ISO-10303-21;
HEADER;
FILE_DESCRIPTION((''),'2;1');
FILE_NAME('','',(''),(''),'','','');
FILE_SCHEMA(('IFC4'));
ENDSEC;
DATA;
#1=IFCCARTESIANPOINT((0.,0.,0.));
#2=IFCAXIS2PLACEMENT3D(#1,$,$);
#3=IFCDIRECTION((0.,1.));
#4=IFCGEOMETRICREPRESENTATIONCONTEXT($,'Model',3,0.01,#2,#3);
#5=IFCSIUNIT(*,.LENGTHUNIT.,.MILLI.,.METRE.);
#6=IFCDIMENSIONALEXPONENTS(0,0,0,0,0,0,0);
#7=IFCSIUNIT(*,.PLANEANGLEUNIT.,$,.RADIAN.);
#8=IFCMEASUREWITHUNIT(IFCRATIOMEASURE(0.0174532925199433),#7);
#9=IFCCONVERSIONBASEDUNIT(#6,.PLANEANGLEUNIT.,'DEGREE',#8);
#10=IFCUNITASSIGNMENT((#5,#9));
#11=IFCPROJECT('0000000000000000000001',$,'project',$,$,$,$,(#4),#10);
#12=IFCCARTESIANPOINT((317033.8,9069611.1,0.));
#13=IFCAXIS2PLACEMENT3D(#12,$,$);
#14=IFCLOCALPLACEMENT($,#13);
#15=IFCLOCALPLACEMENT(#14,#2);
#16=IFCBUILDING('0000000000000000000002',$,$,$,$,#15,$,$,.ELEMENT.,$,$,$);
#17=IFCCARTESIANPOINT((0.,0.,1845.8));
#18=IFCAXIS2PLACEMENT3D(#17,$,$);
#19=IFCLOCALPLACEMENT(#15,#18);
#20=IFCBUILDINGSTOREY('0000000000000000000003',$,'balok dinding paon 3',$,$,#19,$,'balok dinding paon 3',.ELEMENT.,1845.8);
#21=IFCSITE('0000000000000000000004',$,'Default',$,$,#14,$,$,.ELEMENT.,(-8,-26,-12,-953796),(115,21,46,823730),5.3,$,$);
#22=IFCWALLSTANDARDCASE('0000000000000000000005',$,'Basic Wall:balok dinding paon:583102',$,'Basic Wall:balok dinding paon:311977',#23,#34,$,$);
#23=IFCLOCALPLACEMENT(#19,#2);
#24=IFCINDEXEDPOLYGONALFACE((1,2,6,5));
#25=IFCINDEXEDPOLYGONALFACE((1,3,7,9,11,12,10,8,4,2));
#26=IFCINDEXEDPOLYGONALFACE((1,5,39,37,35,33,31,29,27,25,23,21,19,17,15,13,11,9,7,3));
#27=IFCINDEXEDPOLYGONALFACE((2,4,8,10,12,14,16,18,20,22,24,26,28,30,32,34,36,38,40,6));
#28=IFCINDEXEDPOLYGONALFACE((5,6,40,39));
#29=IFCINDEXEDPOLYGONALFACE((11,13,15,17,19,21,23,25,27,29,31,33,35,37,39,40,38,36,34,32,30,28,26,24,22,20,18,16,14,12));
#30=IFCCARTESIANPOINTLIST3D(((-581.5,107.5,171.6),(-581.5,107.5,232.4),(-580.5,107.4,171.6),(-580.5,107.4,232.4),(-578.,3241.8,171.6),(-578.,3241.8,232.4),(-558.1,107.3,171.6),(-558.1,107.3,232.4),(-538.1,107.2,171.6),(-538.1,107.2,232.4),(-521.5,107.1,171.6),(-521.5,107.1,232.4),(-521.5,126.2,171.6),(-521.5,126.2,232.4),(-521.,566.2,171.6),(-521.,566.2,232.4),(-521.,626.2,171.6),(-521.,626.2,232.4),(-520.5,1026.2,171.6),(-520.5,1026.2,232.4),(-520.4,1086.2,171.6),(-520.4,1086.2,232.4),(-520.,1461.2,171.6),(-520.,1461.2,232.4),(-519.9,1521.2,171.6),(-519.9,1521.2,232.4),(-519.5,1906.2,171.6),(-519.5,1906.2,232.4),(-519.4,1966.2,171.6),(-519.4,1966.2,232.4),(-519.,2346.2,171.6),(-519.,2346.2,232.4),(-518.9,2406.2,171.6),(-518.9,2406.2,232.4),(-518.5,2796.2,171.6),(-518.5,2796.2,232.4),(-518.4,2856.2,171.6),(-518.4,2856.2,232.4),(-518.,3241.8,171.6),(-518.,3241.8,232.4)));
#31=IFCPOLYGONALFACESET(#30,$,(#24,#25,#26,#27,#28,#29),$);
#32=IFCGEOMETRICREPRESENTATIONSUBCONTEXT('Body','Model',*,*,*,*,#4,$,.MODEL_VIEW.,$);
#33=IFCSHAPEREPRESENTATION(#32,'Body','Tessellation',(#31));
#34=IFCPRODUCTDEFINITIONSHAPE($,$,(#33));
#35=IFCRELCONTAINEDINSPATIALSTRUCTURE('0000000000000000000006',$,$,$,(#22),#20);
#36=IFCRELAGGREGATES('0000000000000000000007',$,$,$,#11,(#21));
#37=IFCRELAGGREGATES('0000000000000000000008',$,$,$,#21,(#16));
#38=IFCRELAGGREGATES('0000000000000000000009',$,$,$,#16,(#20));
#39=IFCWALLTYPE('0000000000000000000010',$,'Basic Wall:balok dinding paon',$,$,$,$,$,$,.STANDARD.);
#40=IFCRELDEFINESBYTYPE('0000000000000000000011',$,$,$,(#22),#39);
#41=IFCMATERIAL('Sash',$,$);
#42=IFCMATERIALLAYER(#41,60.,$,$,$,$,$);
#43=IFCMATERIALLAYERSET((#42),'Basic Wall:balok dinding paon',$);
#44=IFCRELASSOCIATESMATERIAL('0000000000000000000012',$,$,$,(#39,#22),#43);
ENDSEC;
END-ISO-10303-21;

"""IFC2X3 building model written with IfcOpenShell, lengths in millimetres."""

from ifc_helpers import new_model, entity, si_unit, converted_unit, direction, frame, origin, place, context, subcontext, project, spatial, polyline, outline, extrude, material, layer, layer_set, layer_usage, type_object, element, save


model = new_model("IFC2X3")

# Units and contexts
model_context = context("Model", 3, precision=0.01, world=origin(), true_north=direction((0.0, 1.0)))
body_context = subcontext(model_context, "Body", "Model", "MODEL_VIEW")
ifc_project = project(units=[si_unit("LENGTHUNIT", "METRE", prefix="MILLI"), converted_unit("PLANEANGLEUNIT", "DEGREE", entity("IfcRatioMeasure", 0.0174532925199433), si_unit("PLANEANGLEUNIT", "RADIAN"), dimensions=[0, 0, 0, 0, 0, 0, 0])], contexts=[model_context])

# Site, building, storey
site_placement = place(None, frame((317033.8, 9069611.1, 0.0)))
site = spatial("IfcSite", under=ifc_project, at=site_placement, Name="Default", CompositionType="ELEMENT", RefLatitude=(-8, -26, -12, -953796), RefLongitude=(115, 21, 46, 823730), RefElevation=5.3)
building_placement = place(site_placement, origin())
building = spatial("IfcBuilding", under=site, at=building_placement, CompositionType="ELEMENT")
storey_placement = place(building_placement, frame((0.0, 0.0, 1845.8)))
storey = spatial("IfcBuildingStorey", under=building, at=storey_placement, Name="balok dinding paon 3", LongName="balok dinding paon 3", CompositionType="ELEMENT", Elevation=1845.8)

# Wall
ifc_material_1 = material(Name="Sash")
ifc_layer_1 = layer(ifc_material_1, 60.0)
ifc_layer_set_1 = layer_set([ifc_layer_1], Name="Basic Wall:balok dinding paon")
ifc_layer_usage_1 = layer_usage(ifc_layer_set_1, "AXIS2", "NEGATIVE", 30.0)
wall_type = type_object("IfcWallType", Name="Basic Wall:balok dinding paon", PredefinedType="STANDARD", material=ifc_layer_set_1)
wall_placement = place(storey_placement, frame((-548.0, 3241.8, 171.6), z_axis=(0.0, 0.0, 1.0), x_axis=(-0.00113, -0.999999, 0.0)))
element("IfcWallStandardCase", 1, at=wall_placement, inside=storey, type_object=wall_type, material=ifc_layer_usage_1, Name="Basic Wall:balok dinding paon:583102", ObjectType="Basic Wall:balok dinding paon:311977", context=body_context, shape_type="SweptSolid", body=[
    extrude(outline(polyline([(3134.4, -30.0), (3134.4, -28.9), (3134.5, -6.5), (3134.6, 13.5), (3134.7, 30.0), (3115.6, 30.0), (2675.6, 30.0), (2615.6, 30.0), (2215.6, 30.0), (2155.6, 30.0), (1780.6, 30.0), (1720.6, 30.0), (1335.6, 30.0), (1275.6, 30.0), (895.6, 30.0), (835.6, 30.0), (445.6, 30.0), (385.6, 30.0), (0.0, 30.0), (0.1, -30.0), (3134.4, -30.0)])), origin(), (0.0, 0.0, 1.0), 60.8),
])

save(model, "model.ifc")
